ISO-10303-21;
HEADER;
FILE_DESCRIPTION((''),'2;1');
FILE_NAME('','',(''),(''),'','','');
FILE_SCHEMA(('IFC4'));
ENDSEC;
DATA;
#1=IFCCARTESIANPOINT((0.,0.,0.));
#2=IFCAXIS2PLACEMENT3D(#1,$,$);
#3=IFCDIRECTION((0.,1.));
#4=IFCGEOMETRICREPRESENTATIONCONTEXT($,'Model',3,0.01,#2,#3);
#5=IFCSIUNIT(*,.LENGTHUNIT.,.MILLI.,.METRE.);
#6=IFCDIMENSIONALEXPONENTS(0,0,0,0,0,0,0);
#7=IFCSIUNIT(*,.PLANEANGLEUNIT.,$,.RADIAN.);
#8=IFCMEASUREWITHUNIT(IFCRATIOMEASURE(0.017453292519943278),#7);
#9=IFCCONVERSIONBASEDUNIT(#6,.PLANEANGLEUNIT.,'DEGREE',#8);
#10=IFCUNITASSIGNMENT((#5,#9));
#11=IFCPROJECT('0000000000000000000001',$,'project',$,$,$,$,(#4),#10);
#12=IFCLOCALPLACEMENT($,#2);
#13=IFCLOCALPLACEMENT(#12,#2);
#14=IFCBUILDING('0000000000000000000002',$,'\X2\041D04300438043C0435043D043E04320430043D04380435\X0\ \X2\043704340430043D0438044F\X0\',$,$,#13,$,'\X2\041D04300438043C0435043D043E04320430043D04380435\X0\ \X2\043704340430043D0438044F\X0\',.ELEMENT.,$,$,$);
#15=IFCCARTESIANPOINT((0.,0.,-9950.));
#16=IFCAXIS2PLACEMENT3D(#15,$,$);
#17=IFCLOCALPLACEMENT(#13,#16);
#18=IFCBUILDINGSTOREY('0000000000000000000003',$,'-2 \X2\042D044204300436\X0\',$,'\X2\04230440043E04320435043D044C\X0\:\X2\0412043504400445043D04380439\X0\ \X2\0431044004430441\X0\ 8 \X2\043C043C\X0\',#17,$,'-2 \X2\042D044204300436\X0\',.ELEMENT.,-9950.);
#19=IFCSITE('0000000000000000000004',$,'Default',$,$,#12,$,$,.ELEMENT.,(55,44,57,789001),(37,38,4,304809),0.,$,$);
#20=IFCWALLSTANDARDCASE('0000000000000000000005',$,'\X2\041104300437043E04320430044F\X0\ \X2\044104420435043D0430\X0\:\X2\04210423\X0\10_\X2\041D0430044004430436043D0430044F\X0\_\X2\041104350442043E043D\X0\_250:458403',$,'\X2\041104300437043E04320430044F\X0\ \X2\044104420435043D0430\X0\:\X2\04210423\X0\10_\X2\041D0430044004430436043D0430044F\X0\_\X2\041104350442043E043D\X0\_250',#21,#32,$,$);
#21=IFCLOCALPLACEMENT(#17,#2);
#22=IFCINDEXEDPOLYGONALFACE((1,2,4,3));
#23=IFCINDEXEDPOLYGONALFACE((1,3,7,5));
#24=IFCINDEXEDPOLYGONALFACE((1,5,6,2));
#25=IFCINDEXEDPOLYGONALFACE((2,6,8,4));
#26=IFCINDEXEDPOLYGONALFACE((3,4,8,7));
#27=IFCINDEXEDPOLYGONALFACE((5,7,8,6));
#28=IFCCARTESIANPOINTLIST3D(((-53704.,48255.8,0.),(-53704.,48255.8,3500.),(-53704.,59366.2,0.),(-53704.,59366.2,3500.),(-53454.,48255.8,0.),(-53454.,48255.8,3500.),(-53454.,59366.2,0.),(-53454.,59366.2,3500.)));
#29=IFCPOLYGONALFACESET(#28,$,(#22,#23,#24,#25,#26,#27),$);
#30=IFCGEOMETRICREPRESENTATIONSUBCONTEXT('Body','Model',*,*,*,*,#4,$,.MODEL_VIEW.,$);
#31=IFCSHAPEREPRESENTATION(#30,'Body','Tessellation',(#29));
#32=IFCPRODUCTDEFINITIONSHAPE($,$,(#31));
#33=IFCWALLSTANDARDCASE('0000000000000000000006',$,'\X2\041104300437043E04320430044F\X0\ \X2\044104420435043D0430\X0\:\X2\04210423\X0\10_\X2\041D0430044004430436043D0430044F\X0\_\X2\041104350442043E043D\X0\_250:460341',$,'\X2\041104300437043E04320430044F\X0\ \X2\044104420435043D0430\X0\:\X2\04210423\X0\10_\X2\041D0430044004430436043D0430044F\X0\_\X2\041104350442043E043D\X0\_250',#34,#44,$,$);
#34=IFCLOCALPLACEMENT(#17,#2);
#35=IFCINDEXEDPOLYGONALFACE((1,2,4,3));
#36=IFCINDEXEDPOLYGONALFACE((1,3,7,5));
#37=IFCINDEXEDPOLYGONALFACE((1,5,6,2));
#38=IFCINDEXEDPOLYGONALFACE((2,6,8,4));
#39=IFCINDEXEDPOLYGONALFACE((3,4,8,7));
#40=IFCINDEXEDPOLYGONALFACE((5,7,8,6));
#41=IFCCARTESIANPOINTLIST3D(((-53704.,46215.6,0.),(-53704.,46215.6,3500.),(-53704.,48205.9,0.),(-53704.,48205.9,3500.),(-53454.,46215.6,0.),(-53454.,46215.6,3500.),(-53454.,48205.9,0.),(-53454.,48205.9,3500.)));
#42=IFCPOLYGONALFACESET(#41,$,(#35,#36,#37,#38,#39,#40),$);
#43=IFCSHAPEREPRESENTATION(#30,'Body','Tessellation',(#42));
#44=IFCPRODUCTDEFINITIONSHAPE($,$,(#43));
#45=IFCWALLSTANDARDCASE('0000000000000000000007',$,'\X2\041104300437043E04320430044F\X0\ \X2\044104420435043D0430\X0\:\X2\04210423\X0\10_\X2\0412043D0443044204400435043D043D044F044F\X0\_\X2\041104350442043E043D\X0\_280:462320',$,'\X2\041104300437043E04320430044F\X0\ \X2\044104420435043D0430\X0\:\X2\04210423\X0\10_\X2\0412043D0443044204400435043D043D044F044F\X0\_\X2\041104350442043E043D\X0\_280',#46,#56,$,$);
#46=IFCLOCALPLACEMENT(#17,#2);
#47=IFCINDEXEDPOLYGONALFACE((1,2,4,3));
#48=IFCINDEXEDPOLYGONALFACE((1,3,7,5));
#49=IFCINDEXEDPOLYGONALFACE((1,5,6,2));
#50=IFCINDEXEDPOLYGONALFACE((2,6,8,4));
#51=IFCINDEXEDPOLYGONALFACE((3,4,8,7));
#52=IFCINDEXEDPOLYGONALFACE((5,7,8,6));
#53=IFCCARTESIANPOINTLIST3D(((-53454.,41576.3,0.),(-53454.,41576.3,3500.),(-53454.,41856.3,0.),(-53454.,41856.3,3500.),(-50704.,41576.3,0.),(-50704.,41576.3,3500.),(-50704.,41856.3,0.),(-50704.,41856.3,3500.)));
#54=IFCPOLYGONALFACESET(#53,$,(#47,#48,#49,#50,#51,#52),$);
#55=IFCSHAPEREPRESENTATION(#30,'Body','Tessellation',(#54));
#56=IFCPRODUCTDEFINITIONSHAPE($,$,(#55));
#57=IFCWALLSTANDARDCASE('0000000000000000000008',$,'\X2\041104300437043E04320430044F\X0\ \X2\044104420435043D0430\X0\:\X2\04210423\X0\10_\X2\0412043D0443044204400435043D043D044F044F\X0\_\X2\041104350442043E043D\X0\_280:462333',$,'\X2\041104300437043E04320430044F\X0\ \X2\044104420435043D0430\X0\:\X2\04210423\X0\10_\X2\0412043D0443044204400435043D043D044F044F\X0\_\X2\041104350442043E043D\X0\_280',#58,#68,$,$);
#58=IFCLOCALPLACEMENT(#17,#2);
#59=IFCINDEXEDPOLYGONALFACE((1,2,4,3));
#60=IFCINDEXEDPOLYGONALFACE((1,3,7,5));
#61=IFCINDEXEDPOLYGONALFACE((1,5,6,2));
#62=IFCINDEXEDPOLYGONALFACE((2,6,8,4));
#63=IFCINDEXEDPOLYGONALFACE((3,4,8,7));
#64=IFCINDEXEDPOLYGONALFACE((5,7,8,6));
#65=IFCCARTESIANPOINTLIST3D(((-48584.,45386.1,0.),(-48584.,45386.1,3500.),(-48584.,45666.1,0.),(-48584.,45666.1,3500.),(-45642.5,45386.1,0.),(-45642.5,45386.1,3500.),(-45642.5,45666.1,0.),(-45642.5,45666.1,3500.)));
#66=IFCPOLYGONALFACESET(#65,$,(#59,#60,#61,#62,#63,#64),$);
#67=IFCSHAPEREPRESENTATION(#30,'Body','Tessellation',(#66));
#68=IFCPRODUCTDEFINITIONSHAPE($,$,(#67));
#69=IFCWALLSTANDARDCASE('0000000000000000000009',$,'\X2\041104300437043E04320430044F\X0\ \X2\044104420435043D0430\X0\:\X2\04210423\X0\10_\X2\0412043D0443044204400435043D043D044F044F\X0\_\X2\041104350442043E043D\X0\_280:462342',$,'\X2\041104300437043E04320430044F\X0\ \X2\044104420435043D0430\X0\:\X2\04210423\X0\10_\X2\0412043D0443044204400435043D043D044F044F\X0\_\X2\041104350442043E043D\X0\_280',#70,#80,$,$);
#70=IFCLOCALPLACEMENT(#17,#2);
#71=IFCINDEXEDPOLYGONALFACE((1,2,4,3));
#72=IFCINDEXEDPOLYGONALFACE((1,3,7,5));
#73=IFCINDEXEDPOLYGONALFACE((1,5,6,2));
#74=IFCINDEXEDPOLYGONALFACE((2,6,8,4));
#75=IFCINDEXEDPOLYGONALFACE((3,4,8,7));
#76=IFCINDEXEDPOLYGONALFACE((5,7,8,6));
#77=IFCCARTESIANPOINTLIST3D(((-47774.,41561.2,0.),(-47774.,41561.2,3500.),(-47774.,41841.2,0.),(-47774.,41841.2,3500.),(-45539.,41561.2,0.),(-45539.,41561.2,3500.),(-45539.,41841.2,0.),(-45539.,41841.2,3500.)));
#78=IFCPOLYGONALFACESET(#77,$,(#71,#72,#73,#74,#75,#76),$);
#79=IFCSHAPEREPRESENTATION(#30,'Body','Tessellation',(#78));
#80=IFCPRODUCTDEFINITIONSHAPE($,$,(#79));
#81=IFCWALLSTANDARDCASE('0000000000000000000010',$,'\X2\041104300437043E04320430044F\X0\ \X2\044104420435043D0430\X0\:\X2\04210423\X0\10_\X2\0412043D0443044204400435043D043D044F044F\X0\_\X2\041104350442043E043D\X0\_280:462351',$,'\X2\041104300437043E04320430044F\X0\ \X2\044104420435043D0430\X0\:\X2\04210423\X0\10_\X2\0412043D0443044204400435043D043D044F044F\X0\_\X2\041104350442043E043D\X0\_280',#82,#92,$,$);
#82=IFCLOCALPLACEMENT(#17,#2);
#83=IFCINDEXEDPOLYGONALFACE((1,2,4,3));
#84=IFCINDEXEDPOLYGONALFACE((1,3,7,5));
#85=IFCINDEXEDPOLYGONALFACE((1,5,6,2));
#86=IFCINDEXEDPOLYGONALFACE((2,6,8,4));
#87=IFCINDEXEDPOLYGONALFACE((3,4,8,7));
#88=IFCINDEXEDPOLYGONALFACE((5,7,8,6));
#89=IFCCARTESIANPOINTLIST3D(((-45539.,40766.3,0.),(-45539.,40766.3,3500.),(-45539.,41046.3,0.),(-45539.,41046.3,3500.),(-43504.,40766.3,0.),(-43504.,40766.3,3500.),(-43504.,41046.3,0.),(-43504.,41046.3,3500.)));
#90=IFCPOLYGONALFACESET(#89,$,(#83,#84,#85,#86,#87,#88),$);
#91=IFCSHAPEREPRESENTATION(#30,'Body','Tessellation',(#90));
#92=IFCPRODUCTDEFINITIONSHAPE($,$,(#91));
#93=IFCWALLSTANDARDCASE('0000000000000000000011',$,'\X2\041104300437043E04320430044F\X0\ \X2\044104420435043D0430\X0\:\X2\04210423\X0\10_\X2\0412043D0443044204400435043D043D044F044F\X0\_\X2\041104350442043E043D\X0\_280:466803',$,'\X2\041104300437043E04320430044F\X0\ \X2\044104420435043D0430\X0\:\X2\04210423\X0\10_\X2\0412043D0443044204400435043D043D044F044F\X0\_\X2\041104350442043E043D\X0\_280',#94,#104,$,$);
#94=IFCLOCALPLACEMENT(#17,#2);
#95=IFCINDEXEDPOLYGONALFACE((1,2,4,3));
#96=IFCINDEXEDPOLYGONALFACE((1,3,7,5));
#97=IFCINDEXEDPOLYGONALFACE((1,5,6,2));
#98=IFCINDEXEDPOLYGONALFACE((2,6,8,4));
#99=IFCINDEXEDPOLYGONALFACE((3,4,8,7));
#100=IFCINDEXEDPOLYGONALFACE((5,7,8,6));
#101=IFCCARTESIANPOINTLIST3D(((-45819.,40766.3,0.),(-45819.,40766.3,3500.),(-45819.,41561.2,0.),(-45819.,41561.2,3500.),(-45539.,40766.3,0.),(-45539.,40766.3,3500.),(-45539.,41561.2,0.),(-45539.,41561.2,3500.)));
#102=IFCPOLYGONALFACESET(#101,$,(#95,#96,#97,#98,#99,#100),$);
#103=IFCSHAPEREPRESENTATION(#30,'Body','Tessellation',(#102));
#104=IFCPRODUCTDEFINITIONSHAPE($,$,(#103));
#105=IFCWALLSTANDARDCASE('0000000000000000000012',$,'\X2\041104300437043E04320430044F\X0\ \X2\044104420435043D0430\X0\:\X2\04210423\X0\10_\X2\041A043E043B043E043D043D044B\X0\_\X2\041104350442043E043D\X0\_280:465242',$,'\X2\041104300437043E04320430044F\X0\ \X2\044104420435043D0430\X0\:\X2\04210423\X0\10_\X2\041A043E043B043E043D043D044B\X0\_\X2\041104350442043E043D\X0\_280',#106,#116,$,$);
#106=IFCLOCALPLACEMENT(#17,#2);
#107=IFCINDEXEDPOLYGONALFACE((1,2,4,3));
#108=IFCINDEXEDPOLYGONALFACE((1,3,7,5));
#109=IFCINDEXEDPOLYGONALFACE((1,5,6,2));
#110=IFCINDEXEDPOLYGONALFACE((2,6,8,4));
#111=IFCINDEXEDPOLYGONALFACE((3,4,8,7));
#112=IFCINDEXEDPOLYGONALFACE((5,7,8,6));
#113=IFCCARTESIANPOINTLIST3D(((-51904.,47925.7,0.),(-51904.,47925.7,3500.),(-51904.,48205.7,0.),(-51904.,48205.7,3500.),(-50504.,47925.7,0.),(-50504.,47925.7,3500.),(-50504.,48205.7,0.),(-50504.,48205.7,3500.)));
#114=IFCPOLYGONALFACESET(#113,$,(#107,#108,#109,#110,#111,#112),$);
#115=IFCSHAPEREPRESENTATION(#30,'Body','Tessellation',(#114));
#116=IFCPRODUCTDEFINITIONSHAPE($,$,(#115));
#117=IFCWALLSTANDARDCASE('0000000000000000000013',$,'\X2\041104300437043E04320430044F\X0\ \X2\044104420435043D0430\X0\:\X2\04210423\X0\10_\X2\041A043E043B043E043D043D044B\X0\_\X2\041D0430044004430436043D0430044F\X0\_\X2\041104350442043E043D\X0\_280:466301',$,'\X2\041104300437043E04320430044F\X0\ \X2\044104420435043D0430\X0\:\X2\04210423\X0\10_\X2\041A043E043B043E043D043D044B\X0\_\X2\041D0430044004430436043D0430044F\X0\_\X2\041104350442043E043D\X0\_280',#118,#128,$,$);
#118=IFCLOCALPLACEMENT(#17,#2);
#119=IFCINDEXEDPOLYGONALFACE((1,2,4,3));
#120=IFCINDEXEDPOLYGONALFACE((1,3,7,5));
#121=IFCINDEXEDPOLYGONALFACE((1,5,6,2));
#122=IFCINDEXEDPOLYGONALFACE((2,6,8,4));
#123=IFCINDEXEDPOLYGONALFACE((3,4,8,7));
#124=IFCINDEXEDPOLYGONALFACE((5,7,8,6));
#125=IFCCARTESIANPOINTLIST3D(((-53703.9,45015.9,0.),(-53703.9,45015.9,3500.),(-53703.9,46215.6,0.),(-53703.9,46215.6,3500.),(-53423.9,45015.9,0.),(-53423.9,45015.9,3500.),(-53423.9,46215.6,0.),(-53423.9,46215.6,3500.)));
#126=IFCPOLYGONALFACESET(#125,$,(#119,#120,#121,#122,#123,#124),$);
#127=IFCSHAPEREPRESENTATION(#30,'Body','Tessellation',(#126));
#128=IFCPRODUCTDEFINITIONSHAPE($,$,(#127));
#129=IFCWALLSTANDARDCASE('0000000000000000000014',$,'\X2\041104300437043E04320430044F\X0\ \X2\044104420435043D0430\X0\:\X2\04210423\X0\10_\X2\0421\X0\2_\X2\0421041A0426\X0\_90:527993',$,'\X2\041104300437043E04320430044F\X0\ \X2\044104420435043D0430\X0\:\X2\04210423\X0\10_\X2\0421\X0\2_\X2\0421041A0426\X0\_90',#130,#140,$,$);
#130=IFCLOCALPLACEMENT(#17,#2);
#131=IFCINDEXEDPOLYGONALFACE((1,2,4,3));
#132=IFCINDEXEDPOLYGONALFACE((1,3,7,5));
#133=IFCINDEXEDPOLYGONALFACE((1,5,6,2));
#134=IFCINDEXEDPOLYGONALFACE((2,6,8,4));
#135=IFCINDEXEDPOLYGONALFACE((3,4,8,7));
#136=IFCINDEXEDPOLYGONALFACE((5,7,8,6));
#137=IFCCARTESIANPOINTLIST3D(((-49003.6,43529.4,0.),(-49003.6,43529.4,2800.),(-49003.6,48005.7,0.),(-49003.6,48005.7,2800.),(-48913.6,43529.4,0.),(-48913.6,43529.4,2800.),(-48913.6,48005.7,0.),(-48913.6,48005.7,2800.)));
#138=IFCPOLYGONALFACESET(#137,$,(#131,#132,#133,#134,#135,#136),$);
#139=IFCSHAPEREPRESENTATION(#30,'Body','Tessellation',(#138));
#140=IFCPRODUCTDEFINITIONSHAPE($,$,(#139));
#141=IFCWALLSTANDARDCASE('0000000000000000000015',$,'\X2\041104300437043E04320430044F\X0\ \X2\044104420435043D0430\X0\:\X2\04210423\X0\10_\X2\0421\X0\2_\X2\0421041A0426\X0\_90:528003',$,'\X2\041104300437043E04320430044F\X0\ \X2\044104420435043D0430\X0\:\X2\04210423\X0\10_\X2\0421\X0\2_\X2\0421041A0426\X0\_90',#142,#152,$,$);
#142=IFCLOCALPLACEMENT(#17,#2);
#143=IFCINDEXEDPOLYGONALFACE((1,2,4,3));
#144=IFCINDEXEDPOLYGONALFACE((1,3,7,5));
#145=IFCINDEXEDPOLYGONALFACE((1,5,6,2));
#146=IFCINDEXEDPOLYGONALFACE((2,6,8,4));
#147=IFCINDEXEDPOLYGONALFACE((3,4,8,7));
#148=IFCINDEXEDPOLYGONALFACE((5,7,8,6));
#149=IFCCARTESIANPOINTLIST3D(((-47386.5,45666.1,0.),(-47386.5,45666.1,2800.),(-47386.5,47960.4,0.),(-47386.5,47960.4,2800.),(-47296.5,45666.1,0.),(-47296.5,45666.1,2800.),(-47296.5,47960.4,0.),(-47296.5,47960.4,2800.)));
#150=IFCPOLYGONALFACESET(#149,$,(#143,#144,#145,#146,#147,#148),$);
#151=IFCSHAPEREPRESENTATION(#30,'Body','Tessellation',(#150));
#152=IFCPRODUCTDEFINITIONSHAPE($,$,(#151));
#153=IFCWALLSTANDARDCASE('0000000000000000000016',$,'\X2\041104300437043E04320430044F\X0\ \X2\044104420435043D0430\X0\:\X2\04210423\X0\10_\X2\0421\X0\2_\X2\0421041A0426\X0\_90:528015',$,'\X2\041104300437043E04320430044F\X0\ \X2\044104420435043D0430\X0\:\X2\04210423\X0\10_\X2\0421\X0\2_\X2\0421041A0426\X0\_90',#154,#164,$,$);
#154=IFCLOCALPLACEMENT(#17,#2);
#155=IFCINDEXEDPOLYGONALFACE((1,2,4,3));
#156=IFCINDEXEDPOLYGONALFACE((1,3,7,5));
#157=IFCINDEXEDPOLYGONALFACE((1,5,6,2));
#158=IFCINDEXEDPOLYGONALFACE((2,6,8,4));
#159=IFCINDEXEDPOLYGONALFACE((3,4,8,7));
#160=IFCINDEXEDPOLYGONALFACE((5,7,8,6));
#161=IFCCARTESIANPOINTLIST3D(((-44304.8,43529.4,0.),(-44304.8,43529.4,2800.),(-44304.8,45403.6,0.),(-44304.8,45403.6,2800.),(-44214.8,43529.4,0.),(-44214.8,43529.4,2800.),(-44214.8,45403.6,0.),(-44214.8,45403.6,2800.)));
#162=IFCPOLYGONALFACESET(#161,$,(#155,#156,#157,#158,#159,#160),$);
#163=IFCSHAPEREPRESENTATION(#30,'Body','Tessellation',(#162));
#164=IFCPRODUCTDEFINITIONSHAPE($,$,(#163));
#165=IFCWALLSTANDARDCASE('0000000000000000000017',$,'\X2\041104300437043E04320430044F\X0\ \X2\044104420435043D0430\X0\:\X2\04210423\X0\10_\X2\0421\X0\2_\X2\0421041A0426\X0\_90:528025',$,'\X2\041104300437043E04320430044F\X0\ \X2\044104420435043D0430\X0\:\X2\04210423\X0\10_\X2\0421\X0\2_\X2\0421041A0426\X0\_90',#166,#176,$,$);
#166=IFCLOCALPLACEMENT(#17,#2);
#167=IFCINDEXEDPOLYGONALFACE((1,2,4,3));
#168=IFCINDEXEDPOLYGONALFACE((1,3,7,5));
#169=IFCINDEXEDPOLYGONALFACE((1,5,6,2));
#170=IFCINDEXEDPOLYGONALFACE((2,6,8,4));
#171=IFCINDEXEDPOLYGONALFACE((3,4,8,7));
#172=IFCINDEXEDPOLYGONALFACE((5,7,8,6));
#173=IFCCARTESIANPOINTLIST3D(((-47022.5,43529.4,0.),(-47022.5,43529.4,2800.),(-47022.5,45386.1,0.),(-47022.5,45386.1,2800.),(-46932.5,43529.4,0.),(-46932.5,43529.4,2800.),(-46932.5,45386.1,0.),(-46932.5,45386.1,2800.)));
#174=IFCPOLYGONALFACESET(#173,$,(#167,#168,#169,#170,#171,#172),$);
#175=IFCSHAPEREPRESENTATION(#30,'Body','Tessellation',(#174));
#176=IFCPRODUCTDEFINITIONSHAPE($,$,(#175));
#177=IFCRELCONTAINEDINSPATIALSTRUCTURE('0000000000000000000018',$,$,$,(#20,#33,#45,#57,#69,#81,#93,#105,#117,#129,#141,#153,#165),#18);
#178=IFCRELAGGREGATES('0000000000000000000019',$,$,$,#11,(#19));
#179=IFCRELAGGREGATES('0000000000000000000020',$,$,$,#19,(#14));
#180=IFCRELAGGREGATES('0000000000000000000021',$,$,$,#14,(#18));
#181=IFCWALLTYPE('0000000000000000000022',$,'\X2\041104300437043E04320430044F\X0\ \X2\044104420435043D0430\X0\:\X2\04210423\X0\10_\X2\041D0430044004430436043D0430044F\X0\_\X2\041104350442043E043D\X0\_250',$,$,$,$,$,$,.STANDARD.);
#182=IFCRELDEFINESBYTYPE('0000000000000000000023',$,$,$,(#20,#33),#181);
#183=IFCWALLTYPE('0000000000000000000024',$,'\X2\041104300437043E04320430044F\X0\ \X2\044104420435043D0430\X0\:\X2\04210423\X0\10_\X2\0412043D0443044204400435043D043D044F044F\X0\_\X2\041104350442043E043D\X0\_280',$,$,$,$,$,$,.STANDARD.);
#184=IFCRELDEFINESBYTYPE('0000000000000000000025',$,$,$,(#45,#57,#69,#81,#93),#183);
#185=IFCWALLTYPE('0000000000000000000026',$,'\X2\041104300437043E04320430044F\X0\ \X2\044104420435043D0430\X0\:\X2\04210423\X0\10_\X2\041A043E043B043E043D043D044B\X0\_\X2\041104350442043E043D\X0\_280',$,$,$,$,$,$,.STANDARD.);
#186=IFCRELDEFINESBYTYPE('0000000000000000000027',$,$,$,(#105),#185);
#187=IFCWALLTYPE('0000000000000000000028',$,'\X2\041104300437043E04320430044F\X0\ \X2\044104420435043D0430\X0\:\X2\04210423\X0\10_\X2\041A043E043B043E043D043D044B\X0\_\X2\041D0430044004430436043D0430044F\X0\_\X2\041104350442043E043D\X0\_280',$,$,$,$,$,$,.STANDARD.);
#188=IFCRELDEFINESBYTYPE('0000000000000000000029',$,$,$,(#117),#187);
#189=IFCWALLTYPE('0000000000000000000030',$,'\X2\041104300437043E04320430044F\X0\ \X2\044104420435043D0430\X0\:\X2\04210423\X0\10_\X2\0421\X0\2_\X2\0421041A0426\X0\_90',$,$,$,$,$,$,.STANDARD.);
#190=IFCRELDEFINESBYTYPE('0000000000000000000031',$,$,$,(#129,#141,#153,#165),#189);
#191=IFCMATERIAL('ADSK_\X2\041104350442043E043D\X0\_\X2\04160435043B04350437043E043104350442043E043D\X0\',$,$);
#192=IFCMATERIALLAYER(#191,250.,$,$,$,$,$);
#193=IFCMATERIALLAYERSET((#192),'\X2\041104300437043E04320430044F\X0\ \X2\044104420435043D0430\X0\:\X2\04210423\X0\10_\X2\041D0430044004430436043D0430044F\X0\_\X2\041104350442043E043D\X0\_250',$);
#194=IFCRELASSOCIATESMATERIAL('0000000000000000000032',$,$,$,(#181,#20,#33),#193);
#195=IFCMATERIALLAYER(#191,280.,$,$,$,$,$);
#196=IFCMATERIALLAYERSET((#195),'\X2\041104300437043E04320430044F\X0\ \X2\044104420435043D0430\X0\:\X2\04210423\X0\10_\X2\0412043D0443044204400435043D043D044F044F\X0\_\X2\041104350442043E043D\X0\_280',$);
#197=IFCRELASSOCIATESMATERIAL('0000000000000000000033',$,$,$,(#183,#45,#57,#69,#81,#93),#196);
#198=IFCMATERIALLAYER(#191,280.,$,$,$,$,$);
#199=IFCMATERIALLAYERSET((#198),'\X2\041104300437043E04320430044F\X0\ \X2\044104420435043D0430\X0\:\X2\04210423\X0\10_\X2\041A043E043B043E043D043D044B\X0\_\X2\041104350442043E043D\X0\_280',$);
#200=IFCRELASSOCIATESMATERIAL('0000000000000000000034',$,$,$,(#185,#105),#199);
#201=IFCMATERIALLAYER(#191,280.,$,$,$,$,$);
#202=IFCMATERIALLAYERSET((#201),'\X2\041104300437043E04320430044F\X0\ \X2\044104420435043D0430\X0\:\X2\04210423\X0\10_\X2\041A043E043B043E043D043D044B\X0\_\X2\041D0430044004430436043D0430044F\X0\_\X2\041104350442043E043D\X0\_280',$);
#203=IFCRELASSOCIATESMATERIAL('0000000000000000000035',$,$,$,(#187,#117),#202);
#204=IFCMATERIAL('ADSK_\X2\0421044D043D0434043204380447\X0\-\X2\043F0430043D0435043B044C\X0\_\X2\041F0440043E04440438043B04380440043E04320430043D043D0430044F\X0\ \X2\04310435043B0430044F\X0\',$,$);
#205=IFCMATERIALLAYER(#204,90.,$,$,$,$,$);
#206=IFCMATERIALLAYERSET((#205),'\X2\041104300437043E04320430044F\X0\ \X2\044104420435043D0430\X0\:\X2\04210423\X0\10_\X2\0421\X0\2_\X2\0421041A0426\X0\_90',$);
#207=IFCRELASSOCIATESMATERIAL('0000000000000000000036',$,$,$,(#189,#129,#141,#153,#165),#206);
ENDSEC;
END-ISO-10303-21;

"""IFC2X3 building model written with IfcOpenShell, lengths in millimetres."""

from ifc_helpers import new_model, entity, si_unit, converted_unit, direction, frame, frame_2d, origin, place, context, subcontext, project, spatial, rectangle, extrude, material, layer, layer_set, layer_usage, type_object, element, save


model = new_model("IFC2X3")

# Units and contexts
model_context = context("Model", 3, precision=0.01, world=origin(), true_north=direction((0.0, 1.0)))
body_context = subcontext(model_context, "Body", "Model", "MODEL_VIEW")
ifc_project = project(units=[si_unit("LENGTHUNIT", "METRE", prefix="MILLI"), converted_unit("PLANEANGLEUNIT", "DEGREE", entity("IfcRatioMeasure", 0.017453292519943278), si_unit("PLANEANGLEUNIT", "RADIAN"), dimensions=[0, 0, 0, 0, 0, 0, 0])], contexts=[model_context])

# Site, building, storey
site_placement = place(None, origin())
site = spatial("IfcSite", under=ifc_project, at=site_placement, Name="Default", CompositionType="ELEMENT", RefLatitude=(55, 44, 57, 789001), RefLongitude=(37, 38, 4, 304809), RefElevation=0.0)
building_placement = place(site_placement, origin())
building = spatial("IfcBuilding", under=site, at=building_placement, Name="Наименование здания", LongName="Наименование здания", CompositionType="ELEMENT")
storey_placement = place(building_placement, frame((0.0, 0.0, -9950.0)))
storey = spatial("IfcBuildingStorey", under=building, at=storey_placement, Name="-2 Этаж", ObjectType="Уровень:Верхний брус 8 мм", LongName="-2 Этаж", CompositionType="ELEMENT", Elevation=-9950.0)

# Walls
ifc_material_1 = material(Name="ADSK_Бетон_Железобетон")
ifc_layer_1 = layer(ifc_material_1, 250.0)
ifc_layer_set_1 = layer_set([ifc_layer_1], Name="Базовая стена:СУ10_Наружная_Бетон_250")
ifc_layer_usage_1 = layer_usage(ifc_layer_set_1, "AXIS2", "NEGATIVE", 125.0)
wall_type_1 = type_object("IfcWallType", Name="Базовая стена:СУ10_Наружная_Бетон_250", PredefinedType="STANDARD", material=ifc_layer_set_1)
wall_1_placement = place(storey_placement, frame((-53579.0, 48255.8, 0.0), z_axis=(0.0, 0.0, 1.0), x_axis=(0.0, 1.0, 0.0)))
element("IfcWallStandardCase", 1, at=wall_1_placement, inside=storey, type_object=wall_type_1, material=ifc_layer_usage_1, Name="Базовая стена:СУ10_Наружная_Бетон_250:458403", ObjectType="Базовая стена:СУ10_Наружная_Бетон_250", context=body_context, shape_type="SweptSolid", body=[
    extrude(rectangle(XDim=11110.4, YDim=250.0, at=frame_2d((5555.2, 0.0), x_axis=(-1.0, 0.0))), origin(), (0.0, 0.0, 1.0), 3500.0),
])
wall_2_placement = place(storey_placement, frame((-53579.0, 46215.6, 0.0), z_axis=(0.0, 0.0, 1.0), x_axis=(0.0, 1.0, 0.0)))
element("IfcWallStandardCase", 2, at=wall_2_placement, inside=storey, type_object=wall_type_1, material=ifc_layer_usage_1, Name="Базовая стена:СУ10_Наружная_Бетон_250:460341", ObjectType="Базовая стена:СУ10_Наружная_Бетон_250", context=body_context, shape_type="SweptSolid", body=[
    extrude(rectangle(XDim=1990.3, YDim=250.0, at=frame_2d((995.2, 0.0), x_axis=(-1.0, 0.0))), origin(), (0.0, 0.0, 1.0), 3500.0),
])
ifc_layer_2 = layer(ifc_material_1, 280.0)
ifc_layer_set_2 = layer_set([ifc_layer_2], Name="Базовая стена:СУ10_Внутренняя_Бетон_280")
ifc_layer_usage_2 = layer_usage(ifc_layer_set_2, "AXIS2", "NEGATIVE", 140.0)
wall_type_2 = type_object("IfcWallType", Name="Базовая стена:СУ10_Внутренняя_Бетон_280", PredefinedType="STANDARD", material=ifc_layer_set_2)
wall_3_placement = place(storey_placement, frame((-50704.0, 41716.3, 0.0), z_axis=(0.0, 0.0, 1.0), x_axis=(-1.0, 0.0, 0.0)))
element("IfcWallStandardCase", 3, at=wall_3_placement, inside=storey, type_object=wall_type_2, material=ifc_layer_usage_2, Name="Базовая стена:СУ10_Внутренняя_Бетон_280:462320", ObjectType="Базовая стена:СУ10_Внутренняя_Бетон_280", context=body_context, shape_type="SweptSolid", body=[
    extrude(rectangle(XDim=2750.0, YDim=280.0, at=frame_2d((1375.0, 0.0), x_axis=(-1.0, 0.0))), origin(), (0.0, 0.0, 1.0), 3500.0),
])
wall_4_placement = place(storey_placement, frame((-45642.5, 45526.1, 0.0), z_axis=(0.0, 0.0, 1.0), x_axis=(-1.0, 0.0, 0.0)))
element("IfcWallStandardCase", 4, at=wall_4_placement, inside=storey, type_object=wall_type_2, material=ifc_layer_usage_2, Name="Базовая стена:СУ10_Внутренняя_Бетон_280:462333", ObjectType="Базовая стена:СУ10_Внутренняя_Бетон_280", context=body_context, shape_type="SweptSolid", body=[
    extrude(rectangle(XDim=2941.5, YDim=280.0, at=frame_2d((1470.8, 0.0), x_axis=(-1.0, 0.0))), origin(), (0.0, 0.0, 1.0), 3500.0),
])
wall_5_placement = place(storey_placement, frame((-45539.0, 41701.2, 0.0), z_axis=(0.0, 0.0, 1.0), x_axis=(-1.0, 0.0, 0.0)))
element("IfcWallStandardCase", 5, at=wall_5_placement, inside=storey, type_object=wall_type_2, material=ifc_layer_usage_2, Name="Базовая стена:СУ10_Внутренняя_Бетон_280:462342", ObjectType="Базовая стена:СУ10_Внутренняя_Бетон_280", context=body_context, shape_type="SweptSolid", body=[
    extrude(rectangle(XDim=2234.9, YDim=280.0, at=frame_2d((1117.5, 0.0), x_axis=(-1.0, 0.0))), origin(), (0.0, 0.0, 1.0), 3500.0),
])
wall_6_placement = place(storey_placement, frame((-43504.0, 40906.3, 0.0), z_axis=(0.0, 0.0, 1.0), x_axis=(-1.0, 0.0, 0.0)))
element("IfcWallStandardCase", 6, at=wall_6_placement, inside=storey, type_object=wall_type_2, material=ifc_layer_usage_2, Name="Базовая стена:СУ10_Внутренняя_Бетон_280:462351", ObjectType="Базовая стена:СУ10_Внутренняя_Бетон_280", context=body_context, shape_type="SweptSolid", body=[
    extrude(rectangle(XDim=2035.1, YDim=280.0, at=frame_2d((1017.5, 0.0), x_axis=(-1.0, 0.0))), origin(), (0.0, 0.0, 1.0), 3500.0),
])
wall_7_placement = place(storey_placement, frame((-45679.0, 41561.2, 0.0), z_axis=(0.0, 0.0, 1.0), x_axis=(0.0, -1.0, 0.0)))
element("IfcWallStandardCase", 7, at=wall_7_placement, inside=storey, type_object=wall_type_2, material=ifc_layer_usage_2, Name="Базовая стена:СУ10_Внутренняя_Бетон_280:466803", ObjectType="Базовая стена:СУ10_Внутренняя_Бетон_280", context=body_context, shape_type="SweptSolid", body=[
    extrude(rectangle(XDim=794.9, YDim=280.0, at=frame_2d((397.5, 0.0), x_axis=(-1.0, 0.0))), origin(), (0.0, 0.0, 1.0), 3500.0),
])
ifc_layer_3 = layer(ifc_material_1, 280.0)
ifc_layer_set_3 = layer_set([ifc_layer_3], Name="Базовая стена:СУ10_Колонны_Бетон_280")
ifc_layer_usage_3 = layer_usage(ifc_layer_set_3, "AXIS2", "NEGATIVE", 140.0)
wall_type_3 = type_object("IfcWallType", Name="Базовая стена:СУ10_Колонны_Бетон_280", PredefinedType="STANDARD", material=ifc_layer_set_3)
wall_8_placement = place(storey_placement, frame((-50504.0, 48065.7, 0.0), z_axis=(0.0, 0.0, 1.0), x_axis=(-1.0, 0.0, 0.0)))
element("IfcWallStandardCase", 8, at=wall_8_placement, inside=storey, type_object=wall_type_3, material=ifc_layer_usage_3, Name="Базовая стена:СУ10_Колонны_Бетон_280:465242", ObjectType="Базовая стена:СУ10_Колонны_Бетон_280", context=body_context, shape_type="SweptSolid", body=[
    extrude(rectangle(XDim=1400.0, YDim=280.0, at=frame_2d((700.0, 0.0), x_axis=(-1.0, 0.0))), origin(), (0.0, 0.0, 1.0), 3500.0),
])
ifc_layer_4 = layer(ifc_material_1, 280.0)
ifc_layer_set_4 = layer_set([ifc_layer_4], Name="Базовая стена:СУ10_Колонны_Наружная_Бетон_280")
ifc_layer_usage_4 = layer_usage(ifc_layer_set_4, "AXIS2", "NEGATIVE", 140.0)
wall_type_4 = type_object("IfcWallType", Name="Базовая стена:СУ10_Колонны_Наружная_Бетон_280", PredefinedType="STANDARD", material=ifc_layer_set_4)
wall_9_placement = place(storey_placement, frame((-53563.9, 45015.9, 0.0), z_axis=(0.0, 0.0, 1.0), x_axis=(0.0, 1.0, 0.0)))
element("IfcWallStandardCase", 9, at=wall_9_placement, inside=storey, type_object=wall_type_4, material=ifc_layer_usage_4, Name="Базовая стена:СУ10_Колонны_Наружная_Бетон_280:466301", ObjectType="Базовая стена:СУ10_Колонны_Наружная_Бетон_280", context=body_context, shape_type="SweptSolid", body=[
    extrude(rectangle(XDim=1199.6, YDim=280.0, at=frame_2d((599.8, 0.0), x_axis=(-1.0, 0.0))), origin(), (0.0, 0.0, 1.0), 3500.0),
])
ifc_material_2 = material(Name="ADSK_Сэндвич-панель_Профилированная белая")
ifc_layer_5 = layer(ifc_material_2, 90.0)
ifc_layer_set_5 = layer_set([ifc_layer_5], Name="Базовая стена:СУ10_С2_СКЦ_90")
ifc_layer_usage_5 = layer_usage(ifc_layer_set_5, "AXIS2", "NEGATIVE", 45.0)
wall_type_5 = type_object("IfcWallType", Name="Базовая стена:СУ10_С2_СКЦ_90", PredefinedType="STANDARD", material=ifc_layer_set_5)
wall_10_placement = place(storey_placement, frame((-48958.6, 48005.7, 0.0), z_axis=(0.0, 0.0, 1.0), x_axis=(0.0, -1.0, 0.0)))
element("IfcWallStandardCase", 10, at=wall_10_placement, inside=storey, type_object=wall_type_5, material=ifc_layer_usage_5, Name="Базовая стена:СУ10_С2_СКЦ_90:527993", ObjectType="Базовая стена:СУ10_С2_СКЦ_90", context=body_context, shape_type="SweptSolid", body=[
    extrude(rectangle(XDim=4476.3, YDim=90.0, at=frame_2d((2238.1, 0.0), x_axis=(-1.0, 0.0))), origin(), (0.0, 0.0, 1.0), 2800.0),
])
wall_11_placement = place(storey_placement, frame((-47341.5, 47960.4, 0.0), z_axis=(0.0, 0.0, 1.0), x_axis=(0.0, -1.0, 0.0)))
element("IfcWallStandardCase", 11, at=wall_11_placement, inside=storey, type_object=wall_type_5, material=ifc_layer_usage_5, Name="Базовая стена:СУ10_С2_СКЦ_90:528003", ObjectType="Базовая стена:СУ10_С2_СКЦ_90", context=body_context, shape_type="SweptSolid", body=[
    extrude(rectangle(XDim=2294.3, YDim=90.0, at=frame_2d((1147.2, 0.0), x_axis=(-1.0, 0.0))), origin(), (0.0, 0.0, 1.0), 2800.0),
])
wall_12_placement = place(storey_placement, frame((-44259.8, 45403.6, 0.0), z_axis=(0.0, 0.0, 1.0), x_axis=(0.0, -1.0, 0.0)))
element("IfcWallStandardCase", 12, at=wall_12_placement, inside=storey, type_object=wall_type_5, material=ifc_layer_usage_5, Name="Базовая стена:СУ10_С2_СКЦ_90:528015", ObjectType="Базовая стена:СУ10_С2_СКЦ_90", context=body_context, shape_type="SweptSolid", body=[
    extrude(rectangle(XDim=1874.2, YDim=90.0, at=frame_2d((937.1, 0.0), x_axis=(-1.0, 0.0))), origin(), (0.0, 0.0, 1.0), 2800.0),
])
wall_13_placement = place(storey_placement, frame((-46977.5, 45386.1, 0.0), z_axis=(0.0, 0.0, 1.0), x_axis=(0.0, -1.0, 0.0)))
element("IfcWallStandardCase", 13, at=wall_13_placement, inside=storey, type_object=wall_type_5, material=ifc_layer_usage_5, Name="Базовая стена:СУ10_С2_СКЦ_90:528025", ObjectType="Базовая стена:СУ10_С2_СКЦ_90", context=body_context, shape_type="SweptSolid", body=[
    extrude(rectangle(XDim=1856.7, YDim=90.0, at=frame_2d((928.4, 0.0), x_axis=(-1.0, 0.0))), origin(), (0.0, 0.0, 1.0), 2800.0),
])

save(model, "model.ifc")
